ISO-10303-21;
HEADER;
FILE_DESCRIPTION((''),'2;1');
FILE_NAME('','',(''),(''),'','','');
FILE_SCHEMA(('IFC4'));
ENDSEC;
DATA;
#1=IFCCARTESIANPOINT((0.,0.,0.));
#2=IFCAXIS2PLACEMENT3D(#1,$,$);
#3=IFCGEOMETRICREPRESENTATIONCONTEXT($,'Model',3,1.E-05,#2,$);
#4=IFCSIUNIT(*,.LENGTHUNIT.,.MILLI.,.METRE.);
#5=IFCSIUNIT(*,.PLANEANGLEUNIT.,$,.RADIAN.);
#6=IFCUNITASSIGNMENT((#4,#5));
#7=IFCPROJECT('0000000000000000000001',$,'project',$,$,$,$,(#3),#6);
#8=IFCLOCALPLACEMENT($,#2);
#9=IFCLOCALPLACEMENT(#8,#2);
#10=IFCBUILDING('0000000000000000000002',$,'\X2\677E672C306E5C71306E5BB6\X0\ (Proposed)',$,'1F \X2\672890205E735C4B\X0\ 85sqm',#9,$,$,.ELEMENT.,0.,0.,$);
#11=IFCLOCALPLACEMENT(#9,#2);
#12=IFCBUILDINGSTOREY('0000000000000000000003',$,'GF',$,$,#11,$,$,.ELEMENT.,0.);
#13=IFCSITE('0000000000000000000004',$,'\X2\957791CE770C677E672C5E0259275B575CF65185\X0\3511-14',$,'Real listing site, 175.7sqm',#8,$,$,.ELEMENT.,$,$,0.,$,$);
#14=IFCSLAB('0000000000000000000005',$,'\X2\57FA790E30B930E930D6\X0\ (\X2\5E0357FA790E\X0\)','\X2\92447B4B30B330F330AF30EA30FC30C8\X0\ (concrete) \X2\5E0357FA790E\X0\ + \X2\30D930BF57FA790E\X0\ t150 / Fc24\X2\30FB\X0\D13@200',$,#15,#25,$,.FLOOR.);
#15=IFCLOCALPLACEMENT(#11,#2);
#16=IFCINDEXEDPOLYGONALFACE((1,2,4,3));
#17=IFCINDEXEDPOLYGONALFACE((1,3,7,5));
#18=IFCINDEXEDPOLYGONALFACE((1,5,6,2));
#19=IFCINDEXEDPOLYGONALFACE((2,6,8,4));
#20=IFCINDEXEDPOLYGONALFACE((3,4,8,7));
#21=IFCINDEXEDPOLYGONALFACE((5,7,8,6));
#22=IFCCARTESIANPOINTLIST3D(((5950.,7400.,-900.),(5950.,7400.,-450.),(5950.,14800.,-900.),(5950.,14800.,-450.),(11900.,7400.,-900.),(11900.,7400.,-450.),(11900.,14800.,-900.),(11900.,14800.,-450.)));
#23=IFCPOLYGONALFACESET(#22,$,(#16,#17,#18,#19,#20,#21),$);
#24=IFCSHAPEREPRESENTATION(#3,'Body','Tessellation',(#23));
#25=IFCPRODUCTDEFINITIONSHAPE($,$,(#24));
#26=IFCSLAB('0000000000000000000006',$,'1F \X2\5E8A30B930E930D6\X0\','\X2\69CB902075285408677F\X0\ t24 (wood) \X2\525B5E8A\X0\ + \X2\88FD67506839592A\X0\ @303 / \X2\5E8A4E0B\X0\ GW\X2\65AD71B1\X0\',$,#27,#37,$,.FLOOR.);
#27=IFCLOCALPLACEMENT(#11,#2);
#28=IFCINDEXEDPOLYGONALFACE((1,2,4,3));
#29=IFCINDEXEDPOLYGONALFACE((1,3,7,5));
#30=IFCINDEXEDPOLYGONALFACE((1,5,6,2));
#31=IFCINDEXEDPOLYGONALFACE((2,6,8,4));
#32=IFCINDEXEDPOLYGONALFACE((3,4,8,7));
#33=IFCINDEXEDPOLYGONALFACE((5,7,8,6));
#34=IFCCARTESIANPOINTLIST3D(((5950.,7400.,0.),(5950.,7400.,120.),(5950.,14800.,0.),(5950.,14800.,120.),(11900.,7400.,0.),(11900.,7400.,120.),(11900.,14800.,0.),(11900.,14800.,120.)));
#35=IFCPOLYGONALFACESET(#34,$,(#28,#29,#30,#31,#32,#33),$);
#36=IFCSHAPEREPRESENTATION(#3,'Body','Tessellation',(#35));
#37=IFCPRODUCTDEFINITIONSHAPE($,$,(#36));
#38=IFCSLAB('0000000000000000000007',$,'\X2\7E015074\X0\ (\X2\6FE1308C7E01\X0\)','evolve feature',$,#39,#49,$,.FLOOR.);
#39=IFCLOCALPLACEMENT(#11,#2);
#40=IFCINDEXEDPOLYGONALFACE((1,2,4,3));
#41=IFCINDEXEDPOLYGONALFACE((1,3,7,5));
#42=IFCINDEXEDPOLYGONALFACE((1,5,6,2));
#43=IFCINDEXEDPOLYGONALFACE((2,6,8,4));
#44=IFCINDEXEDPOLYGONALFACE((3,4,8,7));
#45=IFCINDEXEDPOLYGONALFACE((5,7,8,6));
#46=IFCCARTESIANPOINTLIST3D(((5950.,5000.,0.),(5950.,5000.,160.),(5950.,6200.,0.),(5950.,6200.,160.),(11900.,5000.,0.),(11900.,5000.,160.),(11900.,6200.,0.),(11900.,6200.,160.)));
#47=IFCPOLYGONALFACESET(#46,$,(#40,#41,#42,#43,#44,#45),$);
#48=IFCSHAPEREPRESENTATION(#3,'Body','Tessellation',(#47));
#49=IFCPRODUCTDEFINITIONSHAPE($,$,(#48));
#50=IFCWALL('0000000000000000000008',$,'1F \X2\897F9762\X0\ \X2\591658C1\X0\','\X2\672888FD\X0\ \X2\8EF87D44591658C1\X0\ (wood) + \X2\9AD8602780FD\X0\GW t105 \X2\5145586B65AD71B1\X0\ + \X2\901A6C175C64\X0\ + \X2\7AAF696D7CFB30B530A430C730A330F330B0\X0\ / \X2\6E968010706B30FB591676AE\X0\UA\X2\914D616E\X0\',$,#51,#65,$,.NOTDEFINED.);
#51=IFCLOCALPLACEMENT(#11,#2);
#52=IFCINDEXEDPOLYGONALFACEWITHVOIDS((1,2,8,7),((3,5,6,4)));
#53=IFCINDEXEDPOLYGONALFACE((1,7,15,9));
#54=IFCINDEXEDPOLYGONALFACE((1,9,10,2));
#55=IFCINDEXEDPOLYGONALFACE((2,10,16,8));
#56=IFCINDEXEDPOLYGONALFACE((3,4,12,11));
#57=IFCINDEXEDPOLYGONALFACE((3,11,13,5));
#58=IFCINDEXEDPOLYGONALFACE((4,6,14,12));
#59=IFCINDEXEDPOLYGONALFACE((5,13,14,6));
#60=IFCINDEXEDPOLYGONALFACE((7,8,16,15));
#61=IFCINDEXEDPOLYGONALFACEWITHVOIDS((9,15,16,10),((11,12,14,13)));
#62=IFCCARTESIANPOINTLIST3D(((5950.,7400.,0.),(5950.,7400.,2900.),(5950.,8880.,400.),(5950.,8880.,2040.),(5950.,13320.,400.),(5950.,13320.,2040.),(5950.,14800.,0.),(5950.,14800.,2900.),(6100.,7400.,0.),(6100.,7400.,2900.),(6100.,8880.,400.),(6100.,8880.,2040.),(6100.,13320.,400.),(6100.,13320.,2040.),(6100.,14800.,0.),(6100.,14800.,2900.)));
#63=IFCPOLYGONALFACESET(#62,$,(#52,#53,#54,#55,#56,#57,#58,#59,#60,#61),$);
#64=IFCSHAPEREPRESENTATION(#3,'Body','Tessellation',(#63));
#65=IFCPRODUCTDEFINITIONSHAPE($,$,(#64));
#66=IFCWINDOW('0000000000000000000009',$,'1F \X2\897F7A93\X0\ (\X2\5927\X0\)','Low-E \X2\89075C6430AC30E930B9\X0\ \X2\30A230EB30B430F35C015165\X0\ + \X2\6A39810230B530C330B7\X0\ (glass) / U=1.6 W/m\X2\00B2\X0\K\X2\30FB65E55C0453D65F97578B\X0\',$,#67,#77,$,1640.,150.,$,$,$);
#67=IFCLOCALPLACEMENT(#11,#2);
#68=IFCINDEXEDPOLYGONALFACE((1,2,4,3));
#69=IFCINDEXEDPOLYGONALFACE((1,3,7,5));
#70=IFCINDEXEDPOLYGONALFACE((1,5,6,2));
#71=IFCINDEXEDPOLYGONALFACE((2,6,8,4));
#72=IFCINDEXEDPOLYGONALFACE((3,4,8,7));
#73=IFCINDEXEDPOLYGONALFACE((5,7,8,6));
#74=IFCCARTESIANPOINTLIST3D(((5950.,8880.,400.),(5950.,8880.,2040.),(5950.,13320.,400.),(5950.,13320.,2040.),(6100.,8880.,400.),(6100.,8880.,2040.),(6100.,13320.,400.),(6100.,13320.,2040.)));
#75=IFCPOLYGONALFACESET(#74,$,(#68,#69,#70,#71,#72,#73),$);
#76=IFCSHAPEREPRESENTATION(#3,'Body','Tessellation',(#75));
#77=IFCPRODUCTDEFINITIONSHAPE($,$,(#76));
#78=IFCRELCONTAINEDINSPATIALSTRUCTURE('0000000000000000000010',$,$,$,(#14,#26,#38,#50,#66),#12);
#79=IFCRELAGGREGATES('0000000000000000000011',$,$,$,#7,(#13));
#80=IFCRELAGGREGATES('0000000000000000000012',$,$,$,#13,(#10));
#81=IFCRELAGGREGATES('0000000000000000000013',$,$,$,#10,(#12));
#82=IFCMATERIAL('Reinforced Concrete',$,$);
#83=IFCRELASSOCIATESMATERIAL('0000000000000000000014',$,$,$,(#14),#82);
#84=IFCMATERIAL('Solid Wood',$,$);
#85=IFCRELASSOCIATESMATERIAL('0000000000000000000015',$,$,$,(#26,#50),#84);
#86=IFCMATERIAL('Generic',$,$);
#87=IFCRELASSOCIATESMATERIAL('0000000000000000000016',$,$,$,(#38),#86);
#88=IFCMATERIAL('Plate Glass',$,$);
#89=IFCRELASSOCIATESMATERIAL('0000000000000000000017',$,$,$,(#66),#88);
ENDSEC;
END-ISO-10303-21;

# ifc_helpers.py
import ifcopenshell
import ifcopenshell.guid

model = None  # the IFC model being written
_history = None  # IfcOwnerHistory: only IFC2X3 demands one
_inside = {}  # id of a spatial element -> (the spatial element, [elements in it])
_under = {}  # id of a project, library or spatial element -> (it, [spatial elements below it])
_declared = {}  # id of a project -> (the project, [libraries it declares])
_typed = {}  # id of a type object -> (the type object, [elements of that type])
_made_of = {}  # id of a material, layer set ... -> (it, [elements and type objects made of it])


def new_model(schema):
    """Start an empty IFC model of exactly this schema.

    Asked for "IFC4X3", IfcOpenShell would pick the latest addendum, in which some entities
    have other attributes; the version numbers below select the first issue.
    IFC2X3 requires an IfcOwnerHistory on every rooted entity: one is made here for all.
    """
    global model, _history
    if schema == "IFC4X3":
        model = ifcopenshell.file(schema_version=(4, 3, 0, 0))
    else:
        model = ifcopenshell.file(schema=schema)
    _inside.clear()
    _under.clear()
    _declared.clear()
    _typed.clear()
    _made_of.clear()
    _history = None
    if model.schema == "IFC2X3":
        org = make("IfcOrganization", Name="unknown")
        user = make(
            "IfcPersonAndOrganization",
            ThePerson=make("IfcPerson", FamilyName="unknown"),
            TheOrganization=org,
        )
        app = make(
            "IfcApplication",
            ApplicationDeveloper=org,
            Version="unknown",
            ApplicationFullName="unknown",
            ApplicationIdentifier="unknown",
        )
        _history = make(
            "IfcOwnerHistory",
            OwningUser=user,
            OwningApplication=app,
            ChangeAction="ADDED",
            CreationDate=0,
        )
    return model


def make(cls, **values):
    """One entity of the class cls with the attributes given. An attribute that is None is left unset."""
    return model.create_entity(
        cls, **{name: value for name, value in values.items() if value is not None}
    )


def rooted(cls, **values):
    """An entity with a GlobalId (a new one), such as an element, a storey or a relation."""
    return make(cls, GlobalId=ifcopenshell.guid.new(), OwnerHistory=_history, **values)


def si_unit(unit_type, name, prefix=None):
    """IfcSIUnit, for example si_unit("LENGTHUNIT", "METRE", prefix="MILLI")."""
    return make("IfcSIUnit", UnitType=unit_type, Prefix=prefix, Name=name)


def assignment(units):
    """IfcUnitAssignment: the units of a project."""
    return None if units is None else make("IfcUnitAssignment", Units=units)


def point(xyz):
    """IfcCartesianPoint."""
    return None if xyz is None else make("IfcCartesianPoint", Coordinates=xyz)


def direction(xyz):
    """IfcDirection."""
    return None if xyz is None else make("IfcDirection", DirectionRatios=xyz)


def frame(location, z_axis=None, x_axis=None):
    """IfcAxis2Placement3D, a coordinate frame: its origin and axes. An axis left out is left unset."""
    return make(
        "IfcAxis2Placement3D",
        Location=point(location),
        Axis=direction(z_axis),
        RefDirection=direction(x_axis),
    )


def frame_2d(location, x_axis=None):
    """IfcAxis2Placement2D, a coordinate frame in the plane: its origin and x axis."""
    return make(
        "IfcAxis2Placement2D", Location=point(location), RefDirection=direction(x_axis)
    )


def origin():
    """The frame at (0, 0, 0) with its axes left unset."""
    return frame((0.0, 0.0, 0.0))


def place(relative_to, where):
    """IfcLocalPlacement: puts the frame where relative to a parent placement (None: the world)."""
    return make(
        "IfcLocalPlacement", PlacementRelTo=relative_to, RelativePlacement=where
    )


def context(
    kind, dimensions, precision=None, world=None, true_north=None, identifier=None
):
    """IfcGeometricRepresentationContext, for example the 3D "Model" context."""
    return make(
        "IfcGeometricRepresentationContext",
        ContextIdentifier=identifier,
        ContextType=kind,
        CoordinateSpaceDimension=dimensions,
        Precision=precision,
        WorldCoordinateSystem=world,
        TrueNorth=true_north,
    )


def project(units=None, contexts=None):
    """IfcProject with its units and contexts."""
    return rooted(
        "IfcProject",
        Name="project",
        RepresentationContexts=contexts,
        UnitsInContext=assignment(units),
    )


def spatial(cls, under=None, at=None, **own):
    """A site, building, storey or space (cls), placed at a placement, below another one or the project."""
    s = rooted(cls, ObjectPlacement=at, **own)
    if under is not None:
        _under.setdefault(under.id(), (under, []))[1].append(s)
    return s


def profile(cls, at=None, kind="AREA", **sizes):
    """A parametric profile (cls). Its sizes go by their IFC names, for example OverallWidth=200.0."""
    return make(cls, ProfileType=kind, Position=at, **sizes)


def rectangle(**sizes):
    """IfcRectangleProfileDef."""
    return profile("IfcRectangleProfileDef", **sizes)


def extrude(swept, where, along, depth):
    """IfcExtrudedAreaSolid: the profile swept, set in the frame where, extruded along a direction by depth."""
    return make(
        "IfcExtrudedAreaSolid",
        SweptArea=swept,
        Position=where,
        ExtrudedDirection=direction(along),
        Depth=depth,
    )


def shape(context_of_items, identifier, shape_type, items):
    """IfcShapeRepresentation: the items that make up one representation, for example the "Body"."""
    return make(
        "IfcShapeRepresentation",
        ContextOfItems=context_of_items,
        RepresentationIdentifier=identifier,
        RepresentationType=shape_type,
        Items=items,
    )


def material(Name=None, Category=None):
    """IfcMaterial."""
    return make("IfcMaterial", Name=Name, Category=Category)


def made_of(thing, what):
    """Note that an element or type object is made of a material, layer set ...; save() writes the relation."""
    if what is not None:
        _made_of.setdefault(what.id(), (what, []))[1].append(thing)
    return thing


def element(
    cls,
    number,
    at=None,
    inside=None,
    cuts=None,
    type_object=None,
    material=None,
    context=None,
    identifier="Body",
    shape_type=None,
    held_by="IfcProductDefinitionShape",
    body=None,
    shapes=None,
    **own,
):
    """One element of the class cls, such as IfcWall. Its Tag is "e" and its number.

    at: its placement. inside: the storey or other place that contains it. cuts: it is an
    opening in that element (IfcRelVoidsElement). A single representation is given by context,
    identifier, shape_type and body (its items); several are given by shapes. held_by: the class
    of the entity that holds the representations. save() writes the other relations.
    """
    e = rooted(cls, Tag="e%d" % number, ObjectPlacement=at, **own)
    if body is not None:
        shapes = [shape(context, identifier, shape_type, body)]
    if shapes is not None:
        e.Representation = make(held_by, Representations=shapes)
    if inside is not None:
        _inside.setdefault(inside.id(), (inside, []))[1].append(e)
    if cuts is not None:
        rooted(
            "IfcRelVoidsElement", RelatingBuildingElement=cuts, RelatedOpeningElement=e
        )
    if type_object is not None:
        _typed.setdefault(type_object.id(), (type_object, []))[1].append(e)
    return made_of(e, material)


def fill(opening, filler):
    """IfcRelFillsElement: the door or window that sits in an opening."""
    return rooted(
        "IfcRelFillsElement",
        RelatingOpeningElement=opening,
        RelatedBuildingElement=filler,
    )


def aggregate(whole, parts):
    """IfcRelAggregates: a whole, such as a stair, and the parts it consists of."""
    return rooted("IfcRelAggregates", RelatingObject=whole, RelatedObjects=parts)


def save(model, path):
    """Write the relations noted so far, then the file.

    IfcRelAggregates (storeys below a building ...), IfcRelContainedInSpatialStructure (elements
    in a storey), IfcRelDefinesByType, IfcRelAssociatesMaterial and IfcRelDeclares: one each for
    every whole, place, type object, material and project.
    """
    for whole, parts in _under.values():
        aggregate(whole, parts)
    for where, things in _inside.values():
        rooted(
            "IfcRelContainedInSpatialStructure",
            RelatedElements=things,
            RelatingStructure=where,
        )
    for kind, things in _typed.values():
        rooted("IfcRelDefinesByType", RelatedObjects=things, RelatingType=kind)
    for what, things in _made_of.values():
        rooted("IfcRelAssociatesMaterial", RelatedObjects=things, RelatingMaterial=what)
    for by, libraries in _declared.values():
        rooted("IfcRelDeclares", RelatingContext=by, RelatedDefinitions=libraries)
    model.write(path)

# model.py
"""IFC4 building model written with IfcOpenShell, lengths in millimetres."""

from ifc_helpers import new_model, si_unit, frame, frame_2d, origin, place, context, project, spatial, rectangle, extrude, material, element, fill, save


model = new_model("IFC4")

# Units and contexts
model_context = context("Model", 3, precision=1e-05, world=origin())
ifc_project = project(units=[si_unit("LENGTHUNIT", "METRE", prefix="MILLI"), si_unit("PLANEANGLEUNIT", "RADIAN")], contexts=[model_context])

# Site, building, storey
site_placement = place(None, origin())
site = spatial("IfcSite", under=ifc_project, at=site_placement, Name="長野県松本市大字島内3511-14", ObjectType="Real listing site, 175.7sqm", CompositionType="ELEMENT", RefElevation=0.0)
building_placement = place(site_placement, origin())
building = spatial("IfcBuilding", under=site, at=building_placement, Name="松本の山の家 (Proposed)", ObjectType="1F 木造平屋 85sqm", CompositionType="ELEMENT", ElevationOfRefHeight=0.0, ElevationOfTerrain=0.0)
storey_placement = place(building_placement, origin())
storey = spatial("IfcBuildingStorey", under=building, at=storey_placement, Name="GF", CompositionType="ELEMENT", Elevation=0.0)

# Slabs
ifc_material_1 = material(Name="Reinforced Concrete")
slab_1_placement = place(storey_placement, frame((2975.0, 3700.0, -450.0)))
element("IfcSlab", 1, at=slab_1_placement, inside=storey, material=ifc_material_1, Name="基礎スラブ (布基礎)", Description="鉄筋コンクリート (concrete) 布基礎 + ベタ基礎 t150 / Fc24・D13@200", PredefinedType="FLOOR", context=model_context, shape_type="SweptSolid", body=[
    extrude(rectangle(XDim=5950.0, YDim=7400.0, at=frame_2d((2975.0, 3700.0))), frame((2975.0, 3700.0, -450.0)), (0.0, 0.0, 1.0), 450.0),
])
ifc_material_2 = material(Name="Solid Wood")
slab_2_placement = place(storey_placement, frame((2975.0, 3700.0, 0.0)))
element("IfcSlab", 2, at=slab_2_placement, inside=storey, material=ifc_material_2, Name="1F 床スラブ", Description="構造用合板 t24 (wood) 剛床 + 製材根太 @303 / 床下 GW断熱", PredefinedType="FLOOR", context=model_context, shape_type="SweptSolid", body=[
    extrude(rectangle(XDim=5950.0, YDim=7400.0, at=frame_2d((2975.0, 3700.0))), frame((2975.0, 3700.0, 0.0)), (0.0, 0.0, 1.0), 120.0),
])
ifc_material_3 = material(Name="Generic")
slab_3_placement = place(storey_placement, frame((2975.0, 2500.0, 0.0)))
element("IfcSlab", 3, at=slab_3_placement, inside=storey, material=ifc_material_3, Name="縁側 (濡れ縁)", Description="evolve feature", PredefinedType="FLOOR", context=model_context, shape_type="SweptSolid", body=[
    extrude(rectangle(XDim=5950.0, YDim=1200.0, at=frame_2d((2975.0, 600.0))), frame((2975.0, 2500.0, 0.0)), (0.0, 0.0, 1.0), 160.0),
])

# Shared definitions
ifc_material_4 = material(Name="Plate Glass")

# Wall, opening, window
wall_1_placement = place(storey_placement, frame((2975.0, 3700.0, 0.0)))
wall_1 = element("IfcWall", 4, at=wall_1_placement, inside=storey, material=ifc_material_2, Name="1F 西面 外壁", Description="木製 軸組外壁 (wood) + 高性能GW t105 充填断熱 + 通気層 + 窯業系サイディング / 準耐火・外皮UA配慮", PredefinedType="NOTDEFINED", context=model_context, shape_type="SweptSolid", body=[
    extrude(rectangle(XDim=150.0, YDim=7400.0, at=frame_2d((75.0, 3700.0))), frame((2975.0, 3700.0, 0.0)), (0.0, 0.0, 1.0), 2900.0),
])
opening_1_placement = place(storey_placement, frame((2975.0, 4440.0, 200.0)))
opening_1 = element("IfcOpeningElement", 5, at=opening_1_placement, cuts=wall_1, PredefinedType="NOTDEFINED", context=model_context, shape_type="SweptSolid", body=[
    extrude(rectangle(XDim=150.0, YDim=4440.0, at=frame_2d((75.0, 2220.0))), frame((2975.0, 4440.0, 200.0)), (0.0, 0.0, 1.0), 1640.0),
])
window_1_placement = place(storey_placement, frame((2975.0, 4440.0, 200.0)))
window_1 = element("IfcWindow", 6, at=window_1_placement, inside=storey, material=ifc_material_4, Name="1F 西窓 (大)", Description="Low-E 複層ガラス アルゴン封入 + 樹脂サッシ (glass) / U=1.6 W/m²K・日射取得型", OverallHeight=1640.0, OverallWidth=150.0, context=model_context, shape_type="SweptSolid", body=[
    extrude(rectangle(XDim=150.0, YDim=4440.0, at=frame_2d((75.0, 2220.0))), frame((2975.0, 4440.0, 200.0)), (0.0, 0.0, 1.0), 1640.0),
])
fill(opening_1, window_1)

save(model, "model.ifc")
